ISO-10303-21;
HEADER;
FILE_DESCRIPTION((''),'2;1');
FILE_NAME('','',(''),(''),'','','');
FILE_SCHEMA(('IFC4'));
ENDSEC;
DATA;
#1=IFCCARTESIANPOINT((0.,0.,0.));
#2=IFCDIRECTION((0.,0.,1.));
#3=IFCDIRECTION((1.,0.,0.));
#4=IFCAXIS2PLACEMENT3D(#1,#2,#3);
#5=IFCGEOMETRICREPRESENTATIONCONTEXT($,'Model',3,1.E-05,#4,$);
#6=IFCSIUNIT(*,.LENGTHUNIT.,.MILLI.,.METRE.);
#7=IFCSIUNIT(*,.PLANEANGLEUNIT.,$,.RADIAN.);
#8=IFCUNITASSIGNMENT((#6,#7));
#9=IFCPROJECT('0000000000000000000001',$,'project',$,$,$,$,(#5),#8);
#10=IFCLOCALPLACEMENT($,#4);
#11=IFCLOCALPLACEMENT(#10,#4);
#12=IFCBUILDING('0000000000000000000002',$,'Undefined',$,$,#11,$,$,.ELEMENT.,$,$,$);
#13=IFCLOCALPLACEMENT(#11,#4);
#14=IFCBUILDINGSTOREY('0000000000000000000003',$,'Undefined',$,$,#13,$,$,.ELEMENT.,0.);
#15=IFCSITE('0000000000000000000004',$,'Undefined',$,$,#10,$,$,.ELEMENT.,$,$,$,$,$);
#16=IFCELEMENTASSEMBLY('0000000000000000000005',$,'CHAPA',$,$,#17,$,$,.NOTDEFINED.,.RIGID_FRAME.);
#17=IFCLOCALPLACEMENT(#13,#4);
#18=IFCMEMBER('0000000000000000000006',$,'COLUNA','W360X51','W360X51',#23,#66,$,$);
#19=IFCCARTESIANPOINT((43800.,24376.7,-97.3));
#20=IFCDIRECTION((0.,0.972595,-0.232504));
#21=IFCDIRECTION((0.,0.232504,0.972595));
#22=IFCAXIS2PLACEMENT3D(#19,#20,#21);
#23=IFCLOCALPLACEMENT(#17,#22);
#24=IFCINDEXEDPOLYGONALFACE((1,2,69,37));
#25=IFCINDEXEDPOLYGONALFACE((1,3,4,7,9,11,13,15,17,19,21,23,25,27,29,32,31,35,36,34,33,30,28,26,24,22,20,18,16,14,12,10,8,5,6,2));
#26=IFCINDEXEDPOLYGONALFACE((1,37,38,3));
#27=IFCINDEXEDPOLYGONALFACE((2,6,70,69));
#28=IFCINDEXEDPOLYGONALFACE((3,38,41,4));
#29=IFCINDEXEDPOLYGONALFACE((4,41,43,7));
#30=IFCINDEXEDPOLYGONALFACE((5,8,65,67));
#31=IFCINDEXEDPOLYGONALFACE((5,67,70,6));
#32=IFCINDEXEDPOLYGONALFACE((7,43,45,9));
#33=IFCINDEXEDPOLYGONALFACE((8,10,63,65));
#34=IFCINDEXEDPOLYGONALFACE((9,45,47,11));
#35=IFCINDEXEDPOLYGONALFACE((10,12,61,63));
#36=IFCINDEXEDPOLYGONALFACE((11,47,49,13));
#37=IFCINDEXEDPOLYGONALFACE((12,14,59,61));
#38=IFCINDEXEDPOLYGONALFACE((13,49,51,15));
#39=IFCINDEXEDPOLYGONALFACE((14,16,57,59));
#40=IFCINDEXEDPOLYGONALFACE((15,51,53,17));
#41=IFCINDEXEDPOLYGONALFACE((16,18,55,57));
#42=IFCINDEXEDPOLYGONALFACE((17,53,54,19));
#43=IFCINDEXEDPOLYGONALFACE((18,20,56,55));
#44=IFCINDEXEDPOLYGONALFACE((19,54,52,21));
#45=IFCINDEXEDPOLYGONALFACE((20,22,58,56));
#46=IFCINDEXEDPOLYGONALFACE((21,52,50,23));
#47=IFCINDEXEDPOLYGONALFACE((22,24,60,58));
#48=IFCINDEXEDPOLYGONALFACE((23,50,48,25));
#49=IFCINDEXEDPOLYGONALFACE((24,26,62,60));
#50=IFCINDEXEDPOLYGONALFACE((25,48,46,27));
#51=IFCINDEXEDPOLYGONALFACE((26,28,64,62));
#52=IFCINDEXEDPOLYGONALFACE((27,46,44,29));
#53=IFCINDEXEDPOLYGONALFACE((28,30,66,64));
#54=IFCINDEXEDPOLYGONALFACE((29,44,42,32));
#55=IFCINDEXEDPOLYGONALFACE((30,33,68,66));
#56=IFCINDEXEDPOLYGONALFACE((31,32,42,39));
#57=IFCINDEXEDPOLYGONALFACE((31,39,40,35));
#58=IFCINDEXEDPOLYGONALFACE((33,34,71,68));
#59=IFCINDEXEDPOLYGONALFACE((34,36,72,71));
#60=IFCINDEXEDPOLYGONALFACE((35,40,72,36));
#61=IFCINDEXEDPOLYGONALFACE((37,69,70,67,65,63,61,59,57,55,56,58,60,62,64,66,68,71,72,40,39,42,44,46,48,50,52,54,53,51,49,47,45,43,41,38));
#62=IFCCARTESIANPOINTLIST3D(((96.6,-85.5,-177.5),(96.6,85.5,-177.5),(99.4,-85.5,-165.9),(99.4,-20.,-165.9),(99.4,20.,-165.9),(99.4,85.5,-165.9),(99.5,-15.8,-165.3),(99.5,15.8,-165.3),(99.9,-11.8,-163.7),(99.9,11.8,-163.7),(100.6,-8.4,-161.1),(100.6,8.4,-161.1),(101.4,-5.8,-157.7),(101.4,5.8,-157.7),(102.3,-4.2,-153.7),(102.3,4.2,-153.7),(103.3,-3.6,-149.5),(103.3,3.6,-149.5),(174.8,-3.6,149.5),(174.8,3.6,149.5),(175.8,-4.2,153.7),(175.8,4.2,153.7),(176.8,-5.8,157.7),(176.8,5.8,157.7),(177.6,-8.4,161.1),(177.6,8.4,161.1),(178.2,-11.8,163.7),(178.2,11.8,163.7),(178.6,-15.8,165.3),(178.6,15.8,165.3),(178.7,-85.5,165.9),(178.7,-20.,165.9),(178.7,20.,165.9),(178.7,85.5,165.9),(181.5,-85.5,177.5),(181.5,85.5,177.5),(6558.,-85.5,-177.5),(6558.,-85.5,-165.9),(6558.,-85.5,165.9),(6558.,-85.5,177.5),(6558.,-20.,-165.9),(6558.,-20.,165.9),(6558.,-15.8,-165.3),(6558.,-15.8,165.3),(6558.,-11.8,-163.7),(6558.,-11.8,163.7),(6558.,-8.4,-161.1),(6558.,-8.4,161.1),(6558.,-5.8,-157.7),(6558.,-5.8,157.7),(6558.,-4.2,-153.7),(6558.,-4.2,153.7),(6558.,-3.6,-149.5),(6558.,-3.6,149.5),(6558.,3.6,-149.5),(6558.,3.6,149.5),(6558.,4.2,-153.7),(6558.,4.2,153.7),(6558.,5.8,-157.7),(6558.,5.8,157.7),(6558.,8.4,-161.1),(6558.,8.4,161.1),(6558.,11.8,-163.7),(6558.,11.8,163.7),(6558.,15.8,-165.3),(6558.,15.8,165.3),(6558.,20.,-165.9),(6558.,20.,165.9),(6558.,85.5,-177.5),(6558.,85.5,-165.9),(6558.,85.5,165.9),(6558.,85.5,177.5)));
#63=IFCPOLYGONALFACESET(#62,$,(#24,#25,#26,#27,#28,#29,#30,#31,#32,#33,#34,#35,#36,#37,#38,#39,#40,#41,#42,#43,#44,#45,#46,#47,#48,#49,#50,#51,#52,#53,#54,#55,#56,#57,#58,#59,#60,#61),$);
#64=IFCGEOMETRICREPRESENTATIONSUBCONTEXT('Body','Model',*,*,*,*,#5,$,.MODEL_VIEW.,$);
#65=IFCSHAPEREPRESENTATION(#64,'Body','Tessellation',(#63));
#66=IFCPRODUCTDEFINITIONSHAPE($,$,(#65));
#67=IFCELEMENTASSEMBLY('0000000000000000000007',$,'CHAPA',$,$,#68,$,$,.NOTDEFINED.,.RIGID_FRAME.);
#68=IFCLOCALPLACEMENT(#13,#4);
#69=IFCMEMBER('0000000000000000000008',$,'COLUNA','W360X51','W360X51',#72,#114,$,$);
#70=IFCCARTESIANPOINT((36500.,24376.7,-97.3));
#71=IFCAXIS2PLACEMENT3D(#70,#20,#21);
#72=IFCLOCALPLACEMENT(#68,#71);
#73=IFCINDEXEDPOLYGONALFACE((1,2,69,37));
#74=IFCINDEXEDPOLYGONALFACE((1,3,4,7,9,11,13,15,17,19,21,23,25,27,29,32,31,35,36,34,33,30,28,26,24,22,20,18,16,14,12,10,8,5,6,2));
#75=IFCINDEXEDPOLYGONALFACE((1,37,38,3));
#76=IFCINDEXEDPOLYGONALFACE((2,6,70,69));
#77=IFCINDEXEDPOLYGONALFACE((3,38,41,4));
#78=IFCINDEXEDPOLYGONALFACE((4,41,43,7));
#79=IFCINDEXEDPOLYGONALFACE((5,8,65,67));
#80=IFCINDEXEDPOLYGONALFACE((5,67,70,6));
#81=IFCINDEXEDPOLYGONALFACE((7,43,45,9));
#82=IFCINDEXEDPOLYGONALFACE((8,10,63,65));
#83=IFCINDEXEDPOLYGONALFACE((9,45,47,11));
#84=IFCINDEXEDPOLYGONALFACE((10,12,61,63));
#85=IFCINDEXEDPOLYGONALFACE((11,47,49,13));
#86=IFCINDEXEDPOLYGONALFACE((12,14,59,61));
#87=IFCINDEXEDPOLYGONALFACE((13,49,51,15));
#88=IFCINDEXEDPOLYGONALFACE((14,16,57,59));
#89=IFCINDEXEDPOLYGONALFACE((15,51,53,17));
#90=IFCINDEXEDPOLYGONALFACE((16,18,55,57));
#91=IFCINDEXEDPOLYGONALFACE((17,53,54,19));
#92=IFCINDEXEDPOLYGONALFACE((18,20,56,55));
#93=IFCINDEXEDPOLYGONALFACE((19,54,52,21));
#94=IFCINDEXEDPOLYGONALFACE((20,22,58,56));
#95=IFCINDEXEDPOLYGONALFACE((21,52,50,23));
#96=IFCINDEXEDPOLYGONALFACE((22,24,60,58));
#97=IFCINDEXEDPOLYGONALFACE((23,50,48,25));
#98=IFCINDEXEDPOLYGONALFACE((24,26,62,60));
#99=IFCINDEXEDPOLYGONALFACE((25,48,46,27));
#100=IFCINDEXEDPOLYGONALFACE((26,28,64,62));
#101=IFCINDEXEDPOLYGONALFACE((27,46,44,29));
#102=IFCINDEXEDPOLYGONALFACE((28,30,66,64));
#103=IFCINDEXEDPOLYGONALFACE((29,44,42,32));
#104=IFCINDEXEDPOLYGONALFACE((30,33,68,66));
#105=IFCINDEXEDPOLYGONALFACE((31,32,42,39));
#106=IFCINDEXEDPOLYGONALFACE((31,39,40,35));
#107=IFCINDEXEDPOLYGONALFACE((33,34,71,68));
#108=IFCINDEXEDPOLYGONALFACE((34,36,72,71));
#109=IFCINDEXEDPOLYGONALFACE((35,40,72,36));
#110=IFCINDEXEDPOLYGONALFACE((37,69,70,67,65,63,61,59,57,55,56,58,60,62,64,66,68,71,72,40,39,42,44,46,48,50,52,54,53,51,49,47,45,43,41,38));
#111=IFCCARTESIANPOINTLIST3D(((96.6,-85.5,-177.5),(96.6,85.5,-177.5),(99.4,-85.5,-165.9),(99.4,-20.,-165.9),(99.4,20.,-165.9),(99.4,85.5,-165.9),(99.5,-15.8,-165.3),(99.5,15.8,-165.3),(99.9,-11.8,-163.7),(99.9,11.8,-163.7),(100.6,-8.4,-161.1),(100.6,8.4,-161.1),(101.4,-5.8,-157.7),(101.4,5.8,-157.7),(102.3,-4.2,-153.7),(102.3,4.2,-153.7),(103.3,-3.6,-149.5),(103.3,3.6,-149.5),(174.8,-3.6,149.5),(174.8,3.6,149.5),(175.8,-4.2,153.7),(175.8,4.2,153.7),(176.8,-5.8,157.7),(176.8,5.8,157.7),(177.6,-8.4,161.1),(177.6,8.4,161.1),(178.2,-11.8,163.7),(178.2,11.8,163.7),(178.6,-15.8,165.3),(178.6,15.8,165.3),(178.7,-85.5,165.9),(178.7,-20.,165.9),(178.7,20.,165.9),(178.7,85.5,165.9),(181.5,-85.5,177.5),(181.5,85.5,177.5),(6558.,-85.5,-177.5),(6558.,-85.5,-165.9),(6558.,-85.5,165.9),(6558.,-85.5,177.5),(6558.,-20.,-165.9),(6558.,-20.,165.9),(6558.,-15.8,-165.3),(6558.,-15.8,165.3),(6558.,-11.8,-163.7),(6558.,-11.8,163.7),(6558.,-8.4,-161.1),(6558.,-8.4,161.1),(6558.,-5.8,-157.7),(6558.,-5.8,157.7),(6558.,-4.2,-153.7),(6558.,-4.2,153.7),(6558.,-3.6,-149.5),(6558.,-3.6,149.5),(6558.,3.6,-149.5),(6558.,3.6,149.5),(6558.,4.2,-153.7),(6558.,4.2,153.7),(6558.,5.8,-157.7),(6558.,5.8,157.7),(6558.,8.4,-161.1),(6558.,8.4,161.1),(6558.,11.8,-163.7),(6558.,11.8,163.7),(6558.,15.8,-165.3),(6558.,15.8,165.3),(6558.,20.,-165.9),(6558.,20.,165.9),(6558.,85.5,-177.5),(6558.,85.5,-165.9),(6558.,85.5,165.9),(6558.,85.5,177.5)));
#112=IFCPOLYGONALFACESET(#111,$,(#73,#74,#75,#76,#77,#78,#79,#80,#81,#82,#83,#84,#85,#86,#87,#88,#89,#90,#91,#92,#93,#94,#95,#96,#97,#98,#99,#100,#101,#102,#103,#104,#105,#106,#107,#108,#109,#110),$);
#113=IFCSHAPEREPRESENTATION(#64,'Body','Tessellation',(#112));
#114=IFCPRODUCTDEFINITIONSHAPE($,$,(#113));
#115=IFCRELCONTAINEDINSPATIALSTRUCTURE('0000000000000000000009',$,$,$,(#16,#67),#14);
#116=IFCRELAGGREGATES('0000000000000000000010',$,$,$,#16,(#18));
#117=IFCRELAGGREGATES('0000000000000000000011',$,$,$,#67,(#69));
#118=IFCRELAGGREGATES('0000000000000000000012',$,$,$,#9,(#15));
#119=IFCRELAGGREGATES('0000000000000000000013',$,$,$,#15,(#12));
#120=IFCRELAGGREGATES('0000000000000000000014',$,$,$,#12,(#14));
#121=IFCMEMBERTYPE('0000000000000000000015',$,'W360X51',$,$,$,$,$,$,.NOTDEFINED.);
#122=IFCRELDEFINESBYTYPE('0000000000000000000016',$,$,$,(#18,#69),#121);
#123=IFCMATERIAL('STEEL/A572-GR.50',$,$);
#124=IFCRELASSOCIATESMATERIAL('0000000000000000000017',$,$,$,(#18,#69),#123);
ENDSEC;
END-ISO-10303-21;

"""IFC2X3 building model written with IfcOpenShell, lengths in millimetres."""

from ifc_helpers import new_model, si_unit, frame, origin_with_axes, origin_2d_with_axis, place, context, subcontext, project, spatial, i_section, extrude, clip, halfspace, material, type_object, element, aggregate, save


model = new_model("IFC2X3")

# Units and contexts
model_context = context("Model", 3, precision=1e-05, world=origin_with_axes())
body_context = subcontext(model_context, "Body", "Model", "MODEL_VIEW")
ifc_project = project(units=[si_unit("LENGTHUNIT", "METRE", prefix="MILLI"), si_unit("PLANEANGLEUNIT", "RADIAN")], contexts=[model_context])

# Site, building, storey
site_placement = place(None, origin_with_axes())
site = spatial("IfcSite", under=ifc_project, at=site_placement, Name="Undefined", CompositionType="ELEMENT")
building_placement = place(site_placement, origin_with_axes())
building = spatial("IfcBuilding", under=site, at=building_placement, Name="Undefined", CompositionType="ELEMENT")
storey_placement = place(building_placement, origin_with_axes())
storey = spatial("IfcBuildingStorey", under=building, at=storey_placement, Name="Undefined", CompositionType="ELEMENT", Elevation=0.0)

# Shared definitions
ifc_material_1 = material(Name="STEEL/A572-GR.50")

# Element assemblies, members
assembly_1_placement = place(storey_placement, origin_with_axes())
assembly_1 = element("IfcElementAssembly", 1, at=assembly_1_placement, inside=storey, Name="CHAPA", AssemblyPlace="NOTDEFINED", PredefinedType="RIGID_FRAME")
member_type = type_object("IfcMemberType", Name="W360X51", PredefinedType="NOTDEFINED")
member_1_placement = place(assembly_1_placement, frame((43800.0, 24376.7, -97.3), z_axis=(0.0, 0.972595, -0.232504), x_axis=(0.0, 0.232504, 0.972595)))
member_1 = element("IfcMember", 2, at=member_1_placement, type_object=member_type, material=ifc_material_1, Name="COLUNA", Description="W360X51", ObjectType="W360X51", context=body_context, shape_type="Clipping", body=[
    clip(clip(extrude(i_section(OverallWidth=171.0, OverallDepth=355.0, WebThickness=7.2, FlangeThickness=11.6, FilletRadius=16.4, at=origin_2d_with_axis()), frame((6558.0, 0.0, 0.0), z_axis=(-1.0, 0.0, 0.0), x_axis=(0.0, -1.0, 0.0)), (0.0, 0.0, 1.0), 6542.9), halfspace(frame((94.5, -85.5, -186.3), z_axis=(-0.972595, 0.0, 0.232504), x_axis=(0.0, 1.0, 0.0)), False)), halfspace(frame((96.6, 0.0, -177.5), z_axis=(0.972595, 0.0, -0.232504), x_axis=(0.0, -1.0, 0.0)), True)),
])
assembly_2_placement = place(storey_placement, origin_with_axes())
assembly_2 = element("IfcElementAssembly", 3, at=assembly_2_placement, inside=storey, Name="CHAPA", AssemblyPlace="NOTDEFINED", PredefinedType="RIGID_FRAME")
member_2_placement = place(assembly_2_placement, frame((36500.0, 24376.7, -97.3), z_axis=(0.0, 0.972595, -0.232504), x_axis=(0.0, 0.232504, 0.972595)))
member_2 = element("IfcMember", 4, at=member_2_placement, type_object=member_type, material=ifc_material_1, Name="COLUNA", Description="W360X51", ObjectType="W360X51", context=body_context, shape_type="Clipping", body=[
    clip(clip(extrude(i_section(OverallWidth=171.0, OverallDepth=355.0, WebThickness=7.2, FlangeThickness=11.6, FilletRadius=16.4, at=origin_2d_with_axis()), frame((6558.0, 0.0, 0.0), z_axis=(-1.0, 0.0, 0.0), x_axis=(0.0, -1.0, 0.0)), (0.0, 0.0, 1.0), 6542.9), halfspace(frame((94.5, -85.5, -186.3), z_axis=(-0.972595, 0.0, 0.232504), x_axis=(0.0, 1.0, 0.0)), False)), halfspace(frame((96.6, 0.0, -177.5), z_axis=(0.972595, 0.0, -0.232504), x_axis=(0.0, -1.0, 0.0)), True)),
])

aggregate(assembly_1, [member_1])
aggregate(assembly_2, [member_2])

save(model, "model.ifc")
